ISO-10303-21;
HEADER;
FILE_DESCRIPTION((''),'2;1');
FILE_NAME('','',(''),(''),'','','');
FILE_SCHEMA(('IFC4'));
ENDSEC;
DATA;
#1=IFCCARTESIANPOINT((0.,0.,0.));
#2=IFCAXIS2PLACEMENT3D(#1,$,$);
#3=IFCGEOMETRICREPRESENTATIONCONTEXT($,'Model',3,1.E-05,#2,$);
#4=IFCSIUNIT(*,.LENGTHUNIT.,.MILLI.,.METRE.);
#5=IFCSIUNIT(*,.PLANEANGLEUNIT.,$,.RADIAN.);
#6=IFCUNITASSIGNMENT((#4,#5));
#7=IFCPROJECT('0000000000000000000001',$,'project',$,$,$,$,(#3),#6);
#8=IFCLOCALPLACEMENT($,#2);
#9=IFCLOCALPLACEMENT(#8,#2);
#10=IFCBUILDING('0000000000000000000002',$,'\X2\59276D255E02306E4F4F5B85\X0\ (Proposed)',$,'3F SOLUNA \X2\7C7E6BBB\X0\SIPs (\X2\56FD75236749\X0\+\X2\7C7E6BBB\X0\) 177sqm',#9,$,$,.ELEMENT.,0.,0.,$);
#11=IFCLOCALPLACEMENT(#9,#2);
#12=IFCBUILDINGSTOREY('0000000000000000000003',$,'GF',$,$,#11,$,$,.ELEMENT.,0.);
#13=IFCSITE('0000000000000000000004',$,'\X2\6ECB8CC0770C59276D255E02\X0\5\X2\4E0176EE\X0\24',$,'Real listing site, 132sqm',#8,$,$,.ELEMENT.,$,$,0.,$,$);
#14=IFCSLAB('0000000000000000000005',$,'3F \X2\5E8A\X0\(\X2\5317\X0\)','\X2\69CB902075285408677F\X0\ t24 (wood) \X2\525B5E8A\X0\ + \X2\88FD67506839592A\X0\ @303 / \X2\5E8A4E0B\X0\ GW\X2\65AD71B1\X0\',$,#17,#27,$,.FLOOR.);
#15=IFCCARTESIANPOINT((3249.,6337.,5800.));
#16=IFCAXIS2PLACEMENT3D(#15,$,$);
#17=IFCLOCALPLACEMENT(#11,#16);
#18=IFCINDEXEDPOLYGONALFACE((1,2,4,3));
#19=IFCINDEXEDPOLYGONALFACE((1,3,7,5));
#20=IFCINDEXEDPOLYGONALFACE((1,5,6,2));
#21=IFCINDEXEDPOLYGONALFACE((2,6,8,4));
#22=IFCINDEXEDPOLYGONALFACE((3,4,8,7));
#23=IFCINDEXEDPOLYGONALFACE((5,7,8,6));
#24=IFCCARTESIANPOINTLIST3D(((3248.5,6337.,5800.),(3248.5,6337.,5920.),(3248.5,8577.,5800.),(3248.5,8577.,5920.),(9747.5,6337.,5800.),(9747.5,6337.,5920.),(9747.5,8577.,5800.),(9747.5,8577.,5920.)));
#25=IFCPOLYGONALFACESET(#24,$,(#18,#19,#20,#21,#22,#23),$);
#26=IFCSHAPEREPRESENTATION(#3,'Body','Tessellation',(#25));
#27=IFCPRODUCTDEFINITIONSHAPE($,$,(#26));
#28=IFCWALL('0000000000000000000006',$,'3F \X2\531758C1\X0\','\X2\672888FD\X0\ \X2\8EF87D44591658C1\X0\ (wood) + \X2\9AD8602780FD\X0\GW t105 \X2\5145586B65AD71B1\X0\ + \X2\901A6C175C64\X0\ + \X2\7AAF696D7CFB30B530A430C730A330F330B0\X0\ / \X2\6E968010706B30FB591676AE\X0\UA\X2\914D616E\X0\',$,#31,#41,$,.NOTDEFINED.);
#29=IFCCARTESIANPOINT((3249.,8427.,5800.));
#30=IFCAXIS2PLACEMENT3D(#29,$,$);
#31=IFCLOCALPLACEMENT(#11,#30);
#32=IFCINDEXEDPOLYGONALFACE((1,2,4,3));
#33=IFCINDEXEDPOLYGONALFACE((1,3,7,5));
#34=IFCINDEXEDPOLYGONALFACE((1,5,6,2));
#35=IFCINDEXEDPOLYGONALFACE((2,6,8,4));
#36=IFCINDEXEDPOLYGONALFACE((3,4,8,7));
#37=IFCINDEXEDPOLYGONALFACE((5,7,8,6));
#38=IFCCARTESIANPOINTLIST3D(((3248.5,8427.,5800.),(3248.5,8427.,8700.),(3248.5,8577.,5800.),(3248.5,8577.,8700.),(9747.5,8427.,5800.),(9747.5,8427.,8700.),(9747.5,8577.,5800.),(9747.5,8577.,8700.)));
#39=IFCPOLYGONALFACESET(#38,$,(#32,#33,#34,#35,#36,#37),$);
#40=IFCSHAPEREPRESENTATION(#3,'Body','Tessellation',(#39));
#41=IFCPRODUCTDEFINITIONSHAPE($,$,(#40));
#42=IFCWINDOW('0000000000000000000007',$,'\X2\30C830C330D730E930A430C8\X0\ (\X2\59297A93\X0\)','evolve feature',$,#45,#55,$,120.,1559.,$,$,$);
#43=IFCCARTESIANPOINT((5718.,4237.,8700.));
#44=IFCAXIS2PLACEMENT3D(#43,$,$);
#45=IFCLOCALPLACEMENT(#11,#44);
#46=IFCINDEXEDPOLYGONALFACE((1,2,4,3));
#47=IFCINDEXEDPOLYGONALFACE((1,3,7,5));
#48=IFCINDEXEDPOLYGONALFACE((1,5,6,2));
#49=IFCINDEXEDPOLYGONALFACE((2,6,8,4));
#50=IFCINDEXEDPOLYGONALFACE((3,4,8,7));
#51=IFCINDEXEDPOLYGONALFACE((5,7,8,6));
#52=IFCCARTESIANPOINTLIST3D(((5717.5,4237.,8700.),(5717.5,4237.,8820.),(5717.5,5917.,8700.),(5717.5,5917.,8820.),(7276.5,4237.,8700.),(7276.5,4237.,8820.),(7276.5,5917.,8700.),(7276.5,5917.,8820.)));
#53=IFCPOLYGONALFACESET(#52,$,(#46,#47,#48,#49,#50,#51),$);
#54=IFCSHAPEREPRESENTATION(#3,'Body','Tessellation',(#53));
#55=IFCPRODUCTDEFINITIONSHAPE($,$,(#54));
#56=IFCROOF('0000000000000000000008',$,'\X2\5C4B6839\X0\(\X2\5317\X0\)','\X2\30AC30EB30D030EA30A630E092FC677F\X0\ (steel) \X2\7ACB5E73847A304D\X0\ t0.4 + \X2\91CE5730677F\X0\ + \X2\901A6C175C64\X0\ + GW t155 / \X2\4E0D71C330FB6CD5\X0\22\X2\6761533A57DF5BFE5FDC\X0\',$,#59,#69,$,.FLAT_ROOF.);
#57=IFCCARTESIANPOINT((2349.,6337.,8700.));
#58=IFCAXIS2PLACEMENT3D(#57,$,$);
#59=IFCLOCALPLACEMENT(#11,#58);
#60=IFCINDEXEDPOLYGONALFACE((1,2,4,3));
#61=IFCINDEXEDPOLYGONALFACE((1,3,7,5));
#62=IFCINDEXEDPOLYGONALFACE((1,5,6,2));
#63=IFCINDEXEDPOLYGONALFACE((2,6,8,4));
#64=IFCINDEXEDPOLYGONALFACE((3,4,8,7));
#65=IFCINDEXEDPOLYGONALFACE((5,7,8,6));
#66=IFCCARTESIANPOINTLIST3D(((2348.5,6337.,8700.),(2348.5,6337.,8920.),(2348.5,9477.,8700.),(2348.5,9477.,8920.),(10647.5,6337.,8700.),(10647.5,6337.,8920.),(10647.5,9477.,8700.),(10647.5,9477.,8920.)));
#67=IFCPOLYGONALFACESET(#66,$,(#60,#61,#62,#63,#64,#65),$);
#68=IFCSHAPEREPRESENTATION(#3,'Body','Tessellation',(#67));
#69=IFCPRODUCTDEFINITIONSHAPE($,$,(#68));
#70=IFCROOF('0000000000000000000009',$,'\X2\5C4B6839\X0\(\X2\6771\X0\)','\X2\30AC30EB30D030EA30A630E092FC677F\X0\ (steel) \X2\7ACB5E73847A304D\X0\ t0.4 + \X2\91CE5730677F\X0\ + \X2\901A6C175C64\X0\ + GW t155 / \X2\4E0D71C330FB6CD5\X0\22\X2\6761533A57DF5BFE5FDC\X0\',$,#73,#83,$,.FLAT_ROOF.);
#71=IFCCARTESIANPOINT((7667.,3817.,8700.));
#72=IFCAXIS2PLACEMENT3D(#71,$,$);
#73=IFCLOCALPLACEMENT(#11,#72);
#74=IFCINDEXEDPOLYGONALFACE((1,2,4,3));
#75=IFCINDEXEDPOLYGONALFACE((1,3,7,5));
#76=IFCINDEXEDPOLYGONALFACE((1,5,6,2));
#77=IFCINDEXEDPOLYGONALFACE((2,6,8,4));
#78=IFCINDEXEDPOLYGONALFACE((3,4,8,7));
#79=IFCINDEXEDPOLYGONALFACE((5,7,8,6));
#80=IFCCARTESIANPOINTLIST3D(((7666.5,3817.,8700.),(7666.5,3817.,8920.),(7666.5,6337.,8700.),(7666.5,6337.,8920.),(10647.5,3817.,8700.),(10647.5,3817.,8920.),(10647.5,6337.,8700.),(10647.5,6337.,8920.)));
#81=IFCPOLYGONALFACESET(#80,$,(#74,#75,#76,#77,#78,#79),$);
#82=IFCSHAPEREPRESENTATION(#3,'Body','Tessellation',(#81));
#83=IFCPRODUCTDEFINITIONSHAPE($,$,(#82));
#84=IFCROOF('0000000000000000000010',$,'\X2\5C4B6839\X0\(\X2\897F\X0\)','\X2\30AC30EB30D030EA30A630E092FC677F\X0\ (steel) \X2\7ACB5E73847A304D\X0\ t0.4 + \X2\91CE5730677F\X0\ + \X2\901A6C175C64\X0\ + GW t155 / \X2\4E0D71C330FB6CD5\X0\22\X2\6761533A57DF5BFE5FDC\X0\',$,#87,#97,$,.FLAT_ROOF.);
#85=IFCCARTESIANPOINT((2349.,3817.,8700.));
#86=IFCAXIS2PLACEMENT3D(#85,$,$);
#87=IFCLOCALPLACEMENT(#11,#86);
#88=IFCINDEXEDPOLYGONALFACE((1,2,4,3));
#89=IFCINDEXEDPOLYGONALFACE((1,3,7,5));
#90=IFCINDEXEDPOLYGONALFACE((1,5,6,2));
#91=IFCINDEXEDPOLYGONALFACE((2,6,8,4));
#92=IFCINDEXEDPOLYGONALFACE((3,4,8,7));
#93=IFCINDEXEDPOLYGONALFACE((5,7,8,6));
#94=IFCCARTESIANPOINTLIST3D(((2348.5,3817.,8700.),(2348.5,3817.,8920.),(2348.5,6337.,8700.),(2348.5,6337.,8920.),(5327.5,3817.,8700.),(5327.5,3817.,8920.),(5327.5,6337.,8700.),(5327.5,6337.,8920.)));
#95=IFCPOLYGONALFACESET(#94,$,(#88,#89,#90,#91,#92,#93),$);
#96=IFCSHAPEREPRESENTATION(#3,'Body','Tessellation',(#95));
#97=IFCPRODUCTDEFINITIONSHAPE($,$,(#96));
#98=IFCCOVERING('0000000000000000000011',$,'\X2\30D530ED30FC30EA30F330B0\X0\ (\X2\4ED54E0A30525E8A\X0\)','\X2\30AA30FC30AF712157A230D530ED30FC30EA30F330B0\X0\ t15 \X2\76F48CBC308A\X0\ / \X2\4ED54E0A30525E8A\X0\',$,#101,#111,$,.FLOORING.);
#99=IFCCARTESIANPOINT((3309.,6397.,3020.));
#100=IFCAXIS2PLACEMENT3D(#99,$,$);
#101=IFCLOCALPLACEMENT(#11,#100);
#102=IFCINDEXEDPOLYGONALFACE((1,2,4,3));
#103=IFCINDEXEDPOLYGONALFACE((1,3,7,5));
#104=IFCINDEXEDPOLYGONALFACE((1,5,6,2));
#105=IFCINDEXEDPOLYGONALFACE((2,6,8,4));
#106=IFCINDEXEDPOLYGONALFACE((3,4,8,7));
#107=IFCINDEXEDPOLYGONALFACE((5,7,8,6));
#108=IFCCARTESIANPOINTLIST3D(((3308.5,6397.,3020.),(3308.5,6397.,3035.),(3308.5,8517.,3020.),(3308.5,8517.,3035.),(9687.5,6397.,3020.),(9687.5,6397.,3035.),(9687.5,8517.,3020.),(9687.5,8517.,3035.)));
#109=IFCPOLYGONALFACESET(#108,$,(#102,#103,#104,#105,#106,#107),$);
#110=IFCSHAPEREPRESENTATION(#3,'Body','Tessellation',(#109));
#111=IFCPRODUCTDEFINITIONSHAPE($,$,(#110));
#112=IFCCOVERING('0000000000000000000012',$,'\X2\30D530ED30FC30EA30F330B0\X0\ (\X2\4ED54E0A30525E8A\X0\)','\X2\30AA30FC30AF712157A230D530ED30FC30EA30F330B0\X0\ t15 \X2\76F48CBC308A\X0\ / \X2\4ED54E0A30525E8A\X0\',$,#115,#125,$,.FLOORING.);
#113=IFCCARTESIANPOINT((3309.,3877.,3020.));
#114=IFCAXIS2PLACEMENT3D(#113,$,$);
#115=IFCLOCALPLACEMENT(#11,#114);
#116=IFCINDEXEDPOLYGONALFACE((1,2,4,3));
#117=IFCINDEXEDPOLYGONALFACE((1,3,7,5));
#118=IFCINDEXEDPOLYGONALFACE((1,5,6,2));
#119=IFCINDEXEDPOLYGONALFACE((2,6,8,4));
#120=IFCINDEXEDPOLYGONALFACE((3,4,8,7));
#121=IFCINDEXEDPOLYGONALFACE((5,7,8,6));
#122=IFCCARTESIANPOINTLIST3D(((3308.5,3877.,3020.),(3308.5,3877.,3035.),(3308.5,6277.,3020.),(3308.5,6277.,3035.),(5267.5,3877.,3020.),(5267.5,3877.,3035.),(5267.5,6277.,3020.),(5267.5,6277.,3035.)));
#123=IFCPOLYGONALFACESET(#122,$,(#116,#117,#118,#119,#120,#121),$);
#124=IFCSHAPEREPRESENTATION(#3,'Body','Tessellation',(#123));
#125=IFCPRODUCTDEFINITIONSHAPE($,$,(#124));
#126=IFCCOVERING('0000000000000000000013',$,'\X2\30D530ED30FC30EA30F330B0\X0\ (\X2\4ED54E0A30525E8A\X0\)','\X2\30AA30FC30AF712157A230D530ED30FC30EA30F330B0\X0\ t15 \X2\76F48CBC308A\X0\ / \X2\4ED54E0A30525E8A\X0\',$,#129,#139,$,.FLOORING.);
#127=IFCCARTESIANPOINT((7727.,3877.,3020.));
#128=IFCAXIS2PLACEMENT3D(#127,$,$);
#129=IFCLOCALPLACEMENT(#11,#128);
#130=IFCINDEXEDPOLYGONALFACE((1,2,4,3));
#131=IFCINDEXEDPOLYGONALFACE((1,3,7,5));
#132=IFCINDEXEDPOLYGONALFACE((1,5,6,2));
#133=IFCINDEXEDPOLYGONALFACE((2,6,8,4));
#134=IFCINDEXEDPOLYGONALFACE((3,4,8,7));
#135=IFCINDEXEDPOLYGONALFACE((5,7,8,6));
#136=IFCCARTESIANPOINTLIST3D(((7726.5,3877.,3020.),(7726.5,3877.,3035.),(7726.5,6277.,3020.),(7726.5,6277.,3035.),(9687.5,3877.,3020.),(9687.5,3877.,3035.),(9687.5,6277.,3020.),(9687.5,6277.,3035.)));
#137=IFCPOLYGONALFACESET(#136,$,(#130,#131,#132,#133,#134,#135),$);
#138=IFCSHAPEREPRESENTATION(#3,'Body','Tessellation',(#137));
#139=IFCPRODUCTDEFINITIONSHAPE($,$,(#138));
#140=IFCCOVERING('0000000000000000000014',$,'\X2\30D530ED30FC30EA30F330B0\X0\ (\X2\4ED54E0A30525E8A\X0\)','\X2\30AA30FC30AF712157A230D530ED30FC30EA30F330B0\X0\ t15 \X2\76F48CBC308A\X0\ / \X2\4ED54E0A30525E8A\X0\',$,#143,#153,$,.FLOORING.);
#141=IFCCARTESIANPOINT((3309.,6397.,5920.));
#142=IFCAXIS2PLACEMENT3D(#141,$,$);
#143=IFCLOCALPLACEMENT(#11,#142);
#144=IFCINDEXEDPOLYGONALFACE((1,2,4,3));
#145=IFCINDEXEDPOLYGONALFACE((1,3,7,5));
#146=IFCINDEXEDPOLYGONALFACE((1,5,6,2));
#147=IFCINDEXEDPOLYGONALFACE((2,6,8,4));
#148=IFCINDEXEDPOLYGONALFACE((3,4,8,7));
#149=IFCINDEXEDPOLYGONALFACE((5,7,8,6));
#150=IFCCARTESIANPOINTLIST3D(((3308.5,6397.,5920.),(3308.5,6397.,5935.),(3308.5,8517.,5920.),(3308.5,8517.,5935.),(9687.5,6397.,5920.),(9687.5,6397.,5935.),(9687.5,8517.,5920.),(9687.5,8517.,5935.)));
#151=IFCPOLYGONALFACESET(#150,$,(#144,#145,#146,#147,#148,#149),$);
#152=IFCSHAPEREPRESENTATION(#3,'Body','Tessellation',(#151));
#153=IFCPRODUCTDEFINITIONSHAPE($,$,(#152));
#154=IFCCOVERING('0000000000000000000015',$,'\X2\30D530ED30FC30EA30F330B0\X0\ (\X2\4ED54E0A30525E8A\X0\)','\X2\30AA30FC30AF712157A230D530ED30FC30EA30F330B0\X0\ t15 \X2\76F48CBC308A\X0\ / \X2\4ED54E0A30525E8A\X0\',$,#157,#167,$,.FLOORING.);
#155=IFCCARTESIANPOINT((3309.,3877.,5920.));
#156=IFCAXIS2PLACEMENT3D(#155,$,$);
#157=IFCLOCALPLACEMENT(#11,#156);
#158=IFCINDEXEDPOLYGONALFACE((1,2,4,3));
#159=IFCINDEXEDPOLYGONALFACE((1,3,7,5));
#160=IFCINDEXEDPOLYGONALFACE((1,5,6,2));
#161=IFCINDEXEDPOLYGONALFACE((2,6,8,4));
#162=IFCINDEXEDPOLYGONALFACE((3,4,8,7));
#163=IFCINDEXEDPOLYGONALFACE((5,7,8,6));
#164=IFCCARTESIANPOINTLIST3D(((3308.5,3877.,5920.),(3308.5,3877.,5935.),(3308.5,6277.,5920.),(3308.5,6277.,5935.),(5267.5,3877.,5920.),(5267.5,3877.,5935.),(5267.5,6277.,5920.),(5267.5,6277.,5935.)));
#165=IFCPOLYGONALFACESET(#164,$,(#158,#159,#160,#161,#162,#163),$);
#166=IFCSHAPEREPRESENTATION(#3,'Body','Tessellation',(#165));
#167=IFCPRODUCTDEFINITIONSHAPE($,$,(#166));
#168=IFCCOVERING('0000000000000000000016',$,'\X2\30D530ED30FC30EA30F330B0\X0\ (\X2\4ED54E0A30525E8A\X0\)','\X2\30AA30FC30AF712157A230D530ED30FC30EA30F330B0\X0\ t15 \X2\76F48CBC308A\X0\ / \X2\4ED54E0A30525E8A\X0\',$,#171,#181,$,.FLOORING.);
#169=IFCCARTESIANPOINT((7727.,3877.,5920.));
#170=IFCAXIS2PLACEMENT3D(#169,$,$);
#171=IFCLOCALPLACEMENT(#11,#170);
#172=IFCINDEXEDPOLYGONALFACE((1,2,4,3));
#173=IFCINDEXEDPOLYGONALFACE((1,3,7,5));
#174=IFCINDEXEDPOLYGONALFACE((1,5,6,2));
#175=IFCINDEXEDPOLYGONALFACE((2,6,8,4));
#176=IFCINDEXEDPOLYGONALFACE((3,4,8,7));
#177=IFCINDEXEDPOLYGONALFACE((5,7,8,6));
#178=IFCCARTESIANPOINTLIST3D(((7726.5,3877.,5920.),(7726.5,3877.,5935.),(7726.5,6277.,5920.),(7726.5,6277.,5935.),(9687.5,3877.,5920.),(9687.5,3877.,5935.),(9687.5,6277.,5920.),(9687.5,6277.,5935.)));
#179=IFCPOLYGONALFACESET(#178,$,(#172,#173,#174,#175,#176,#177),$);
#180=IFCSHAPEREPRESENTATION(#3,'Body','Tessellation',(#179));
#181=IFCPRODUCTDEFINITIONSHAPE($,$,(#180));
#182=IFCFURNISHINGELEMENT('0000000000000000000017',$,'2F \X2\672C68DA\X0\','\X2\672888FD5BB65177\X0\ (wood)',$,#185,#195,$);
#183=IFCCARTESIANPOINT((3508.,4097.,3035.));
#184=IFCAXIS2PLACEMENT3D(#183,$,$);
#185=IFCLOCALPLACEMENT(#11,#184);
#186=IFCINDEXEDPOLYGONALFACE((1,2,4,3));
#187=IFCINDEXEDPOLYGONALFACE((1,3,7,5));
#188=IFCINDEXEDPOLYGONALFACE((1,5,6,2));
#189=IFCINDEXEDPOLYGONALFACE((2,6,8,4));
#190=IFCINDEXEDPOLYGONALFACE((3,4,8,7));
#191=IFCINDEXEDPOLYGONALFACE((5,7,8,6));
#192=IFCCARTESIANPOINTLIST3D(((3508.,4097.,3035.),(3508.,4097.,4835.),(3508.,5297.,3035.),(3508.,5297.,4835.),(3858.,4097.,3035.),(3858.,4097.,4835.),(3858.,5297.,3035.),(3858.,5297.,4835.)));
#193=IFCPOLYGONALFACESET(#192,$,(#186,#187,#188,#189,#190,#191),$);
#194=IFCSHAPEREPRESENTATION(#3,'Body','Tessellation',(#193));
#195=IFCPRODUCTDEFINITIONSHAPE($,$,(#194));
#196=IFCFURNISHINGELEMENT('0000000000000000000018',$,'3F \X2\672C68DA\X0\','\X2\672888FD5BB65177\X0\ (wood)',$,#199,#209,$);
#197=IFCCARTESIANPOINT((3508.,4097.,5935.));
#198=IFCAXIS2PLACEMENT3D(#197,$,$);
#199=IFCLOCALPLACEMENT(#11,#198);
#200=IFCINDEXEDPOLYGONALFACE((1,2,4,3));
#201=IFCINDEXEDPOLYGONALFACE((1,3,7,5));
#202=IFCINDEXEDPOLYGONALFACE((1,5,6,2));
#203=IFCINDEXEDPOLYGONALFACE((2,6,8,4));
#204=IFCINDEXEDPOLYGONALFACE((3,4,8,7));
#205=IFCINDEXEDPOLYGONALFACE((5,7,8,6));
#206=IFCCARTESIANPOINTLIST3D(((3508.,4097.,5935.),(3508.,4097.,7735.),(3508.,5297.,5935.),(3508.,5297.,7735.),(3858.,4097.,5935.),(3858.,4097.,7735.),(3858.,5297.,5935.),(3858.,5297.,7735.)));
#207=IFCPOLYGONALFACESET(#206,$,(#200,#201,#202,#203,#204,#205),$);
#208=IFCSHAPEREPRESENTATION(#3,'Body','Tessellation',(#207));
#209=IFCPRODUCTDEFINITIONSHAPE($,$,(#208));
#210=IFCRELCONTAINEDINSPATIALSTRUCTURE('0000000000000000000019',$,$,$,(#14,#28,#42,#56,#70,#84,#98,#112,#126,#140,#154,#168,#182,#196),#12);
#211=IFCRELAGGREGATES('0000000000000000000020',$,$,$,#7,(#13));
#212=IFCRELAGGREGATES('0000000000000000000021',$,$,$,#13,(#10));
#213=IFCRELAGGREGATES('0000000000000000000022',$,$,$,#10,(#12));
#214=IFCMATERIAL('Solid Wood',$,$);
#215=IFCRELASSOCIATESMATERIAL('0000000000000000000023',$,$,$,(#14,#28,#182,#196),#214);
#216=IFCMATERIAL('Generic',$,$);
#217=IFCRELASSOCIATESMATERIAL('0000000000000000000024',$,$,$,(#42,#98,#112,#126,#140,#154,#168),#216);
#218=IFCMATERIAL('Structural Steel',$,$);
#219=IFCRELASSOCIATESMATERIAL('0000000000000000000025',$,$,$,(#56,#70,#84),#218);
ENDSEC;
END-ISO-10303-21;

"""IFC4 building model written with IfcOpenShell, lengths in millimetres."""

from ifc_helpers import new_model, si_unit, frame, frame_2d, origin, place, context, project, spatial, rectangle, extrude, material, element, save


model = new_model("IFC4")

# Units and contexts
model_context = context("Model", 3, precision=1e-05, world=origin())
ifc_project = project(units=[si_unit("LENGTHUNIT", "METRE", prefix="MILLI"), si_unit("PLANEANGLEUNIT", "RADIAN")], contexts=[model_context])

# Site, building, storey
site_placement = place(None, origin())
site = spatial("IfcSite", under=ifc_project, at=site_placement, Name="滋賀県大津市5丁目24", ObjectType="Real listing site, 132sqm", CompositionType="ELEMENT", RefElevation=0.0)
building_placement = place(site_placement, origin())
building = spatial("IfcBuilding", under=site, at=building_placement, Name="大津市の住宅 (Proposed)", ObjectType="3F SOLUNA 籾殻SIPs (国産杉+籾殻) 177sqm", CompositionType="ELEMENT", ElevationOfRefHeight=0.0, ElevationOfTerrain=0.0)
storey_placement = place(building_placement, origin())
storey = spatial("IfcBuildingStorey", under=building, at=storey_placement, Name="GF", CompositionType="ELEMENT", Elevation=0.0)

# Slab
ifc_material_1 = material(Name="Solid Wood")
slab_placement = place(storey_placement, frame((3249.0, 6337.0, 5800.0)))
element("IfcSlab", 1, at=slab_placement, inside=storey, material=ifc_material_1, Name="3F 床(北)", Description="構造用合板 t24 (wood) 剛床 + 製材根太 @303 / 床下 GW断熱", PredefinedType="FLOOR", context=model_context, shape_type="SweptSolid", body=[
    extrude(rectangle(XDim=6499.0, YDim=2240.0, at=frame_2d((3249.0, 1120.0))), frame((3249.0, 6337.0, 5800.0)), (0.0, 0.0, 1.0), 120.0),
])

# Wall
wall_1_placement = place(storey_placement, frame((3249.0, 8427.0, 5800.0)))
element("IfcWall", 2, at=wall_1_placement, inside=storey, material=ifc_material_1, Name="3F 北壁", Description="木製 軸組外壁 (wood) + 高性能GW t105 充填断熱 + 通気層 + 窯業系サイディング / 準耐火・外皮UA配慮", PredefinedType="NOTDEFINED", context=model_context, shape_type="SweptSolid", body=[
    extrude(rectangle(XDim=6499.0, YDim=150.0, at=frame_2d((3249.0, 75.0))), frame((3249.0, 8427.0, 5800.0)), (0.0, 0.0, 1.0), 2900.0),
])

# Window
ifc_material_2 = material(Name="Generic")
window_1_placement = place(storey_placement, frame((5718.0, 4237.0, 8700.0)))
element("IfcWindow", 3, at=window_1_placement, inside=storey, material=ifc_material_2, Name="トップライト (天窓)", Description="evolve feature", OverallHeight=120.0, OverallWidth=1559.0, context=model_context, shape_type="SweptSolid", body=[
    extrude(rectangle(XDim=1559.0, YDim=1680.0, at=frame_2d((779.0, 840.0))), frame((5718.0, 4237.0, 8700.0)), (0.0, 0.0, 1.0), 120.0),
])

# Roofs
ifc_material_3 = material(Name="Structural Steel")
roof_1_placement = place(storey_placement, frame((2349.0, 6337.0, 8700.0)))
element("IfcRoof", 4, at=roof_1_placement, inside=storey, material=ifc_material_3, Name="屋根(北)", Description="ガルバリウム鋼板 (steel) 立平葺き t0.4 + 野地板 + 通気層 + GW t155 / 不燃・法22条区域対応", PredefinedType="FLAT_ROOF", context=model_context, shape_type="SweptSolid", body=[
    extrude(rectangle(XDim=8299.0, YDim=3140.0, at=frame_2d((4149.0, 1570.0))), frame((2349.0, 6337.0, 8700.0)), (0.0, 0.0, 1.0), 220.0),
])
roof_2_placement = place(storey_placement, frame((7667.0, 3817.0, 8700.0)))
element("IfcRoof", 5, at=roof_2_placement, inside=storey, material=ifc_material_3, Name="屋根(東)", Description="ガルバリウム鋼板 (steel) 立平葺き t0.4 + 野地板 + 通気層 + GW t155 / 不燃・法22条区域対応", PredefinedType="FLAT_ROOF", context=model_context, shape_type="SweptSolid", body=[
    extrude(rectangle(XDim=2981.0, YDim=2520.0, at=frame_2d((1490.0, 1260.0))), frame((7667.0, 3817.0, 8700.0)), (0.0, 0.0, 1.0), 220.0),
])
roof_3_placement = place(storey_placement, frame((2349.0, 3817.0, 8700.0)))
element("IfcRoof", 6, at=roof_3_placement, inside=storey, material=ifc_material_3, Name="屋根(西)", Description="ガルバリウム鋼板 (steel) 立平葺き t0.4 + 野地板 + 通気層 + GW t155 / 不燃・法22条区域対応", PredefinedType="FLAT_ROOF", context=model_context, shape_type="SweptSolid", body=[
    extrude(rectangle(XDim=2979.0, YDim=2520.0, at=frame_2d((1489.0, 1260.0))), frame((2349.0, 3817.0, 8700.0)), (0.0, 0.0, 1.0), 220.0),
])

# Coverings
covering_1_placement = place(storey_placement, frame((3309.0, 6397.0, 3020.0)))
element("IfcCovering", 7, at=covering_1_placement, inside=storey, material=ifc_material_2, Name="フローリング (仕上げ床)", Description="オーク無垢フローリング t15 直貼り / 仕上げ床", PredefinedType="FLOORING", context=model_context, shape_type="SweptSolid", body=[
    extrude(rectangle(XDim=6379.0, YDim=2120.0, at=frame_2d((3189.0, 1060.0))), frame((3309.0, 6397.0, 3020.0)), (0.0, 0.0, 1.0), 15.0),
])
covering_2_placement = place(storey_placement, frame((3309.0, 3877.0, 3020.0)))
element("IfcCovering", 8, at=covering_2_placement, inside=storey, material=ifc_material_2, Name="フローリング (仕上げ床)", Description="オーク無垢フローリング t15 直貼り / 仕上げ床", PredefinedType="FLOORING", context=model_context, shape_type="SweptSolid", body=[
    extrude(rectangle(XDim=1959.0, YDim=2400.0, at=frame_2d((979.0, 1200.0))), frame((3309.0, 3877.0, 3020.0)), (0.0, 0.0, 1.0), 15.0),
])
covering_3_placement = place(storey_placement, frame((7727.0, 3877.0, 3020.0)))
element("IfcCovering", 9, at=covering_3_placement, inside=storey, material=ifc_material_2, Name="フローリング (仕上げ床)", Description="オーク無垢フローリング t15 直貼り / 仕上げ床", PredefinedType="FLOORING", context=model_context, shape_type="SweptSolid", body=[
    extrude(rectangle(XDim=1961.0, YDim=2400.0, at=frame_2d((980.0, 1200.0))), frame((7727.0, 3877.0, 3020.0)), (0.0, 0.0, 1.0), 15.0),
])
covering_4_placement = place(storey_placement, frame((3309.0, 6397.0, 5920.0)))
element("IfcCovering", 10, at=covering_4_placement, inside=storey, material=ifc_material_2, Name="フローリング (仕上げ床)", Description="オーク無垢フローリング t15 直貼り / 仕上げ床", PredefinedType="FLOORING", context=model_context, shape_type="SweptSolid", body=[
    extrude(rectangle(XDim=6379.0, YDim=2120.0, at=frame_2d((3189.0, 1060.0))), frame((3309.0, 6397.0, 5920.0)), (0.0, 0.0, 1.0), 15.0),
])
covering_5_placement = place(storey_placement, frame((3309.0, 3877.0, 5920.0)))
element("IfcCovering", 11, at=covering_5_placement, inside=storey, material=ifc_material_2, Name="フローリング (仕上げ床)", Description="オーク無垢フローリング t15 直貼り / 仕上げ床", PredefinedType="FLOORING", context=model_context, shape_type="SweptSolid", body=[
    extrude(rectangle(XDim=1959.0, YDim=2400.0, at=frame_2d((979.0, 1200.0))), frame((3309.0, 3877.0, 5920.0)), (0.0, 0.0, 1.0), 15.0),
])
covering_6_placement = place(storey_placement, frame((7727.0, 3877.0, 5920.0)))
element("IfcCovering", 12, at=covering_6_placement, inside=storey, material=ifc_material_2, Name="フローリング (仕上げ床)", Description="オーク無垢フローリング t15 直貼り / 仕上げ床", PredefinedType="FLOORING", context=model_context, shape_type="SweptSolid", body=[
    extrude(rectangle(XDim=1961.0, YDim=2400.0, at=frame_2d((980.0, 1200.0))), frame((7727.0, 3877.0, 5920.0)), (0.0, 0.0, 1.0), 15.0),
])

# Furnishing elements
furnishing_1_placement = place(storey_placement, frame((3508.0, 4097.0, 3035.0)))
element("IfcFurnishingElement", 13, at=furnishing_1_placement, inside=storey, material=ifc_material_1, Name="2F 本棚", Description="木製家具 (wood)", context=model_context, shape_type="SweptSolid", body=[
    extrude(rectangle(XDim=350.0, YDim=1200.0, at=frame_2d((175.0, 600.0))), frame((3508.0, 4097.0, 3035.0)), (0.0, 0.0, 1.0), 1800.0),
])
furnishing_2_placement = place(storey_placement, frame((3508.0, 4097.0, 5935.0)))
element("IfcFurnishingElement", 14, at=furnishing_2_placement, inside=storey, material=ifc_material_1, Name="3F 本棚", Description="木製家具 (wood)", context=model_context, shape_type="SweptSolid", body=[
    extrude(rectangle(XDim=350.0, YDim=1200.0, at=frame_2d((175.0, 600.0))), frame((3508.0, 4097.0, 5935.0)), (0.0, 0.0, 1.0), 1800.0),
])

save(model, "model.ifc")
